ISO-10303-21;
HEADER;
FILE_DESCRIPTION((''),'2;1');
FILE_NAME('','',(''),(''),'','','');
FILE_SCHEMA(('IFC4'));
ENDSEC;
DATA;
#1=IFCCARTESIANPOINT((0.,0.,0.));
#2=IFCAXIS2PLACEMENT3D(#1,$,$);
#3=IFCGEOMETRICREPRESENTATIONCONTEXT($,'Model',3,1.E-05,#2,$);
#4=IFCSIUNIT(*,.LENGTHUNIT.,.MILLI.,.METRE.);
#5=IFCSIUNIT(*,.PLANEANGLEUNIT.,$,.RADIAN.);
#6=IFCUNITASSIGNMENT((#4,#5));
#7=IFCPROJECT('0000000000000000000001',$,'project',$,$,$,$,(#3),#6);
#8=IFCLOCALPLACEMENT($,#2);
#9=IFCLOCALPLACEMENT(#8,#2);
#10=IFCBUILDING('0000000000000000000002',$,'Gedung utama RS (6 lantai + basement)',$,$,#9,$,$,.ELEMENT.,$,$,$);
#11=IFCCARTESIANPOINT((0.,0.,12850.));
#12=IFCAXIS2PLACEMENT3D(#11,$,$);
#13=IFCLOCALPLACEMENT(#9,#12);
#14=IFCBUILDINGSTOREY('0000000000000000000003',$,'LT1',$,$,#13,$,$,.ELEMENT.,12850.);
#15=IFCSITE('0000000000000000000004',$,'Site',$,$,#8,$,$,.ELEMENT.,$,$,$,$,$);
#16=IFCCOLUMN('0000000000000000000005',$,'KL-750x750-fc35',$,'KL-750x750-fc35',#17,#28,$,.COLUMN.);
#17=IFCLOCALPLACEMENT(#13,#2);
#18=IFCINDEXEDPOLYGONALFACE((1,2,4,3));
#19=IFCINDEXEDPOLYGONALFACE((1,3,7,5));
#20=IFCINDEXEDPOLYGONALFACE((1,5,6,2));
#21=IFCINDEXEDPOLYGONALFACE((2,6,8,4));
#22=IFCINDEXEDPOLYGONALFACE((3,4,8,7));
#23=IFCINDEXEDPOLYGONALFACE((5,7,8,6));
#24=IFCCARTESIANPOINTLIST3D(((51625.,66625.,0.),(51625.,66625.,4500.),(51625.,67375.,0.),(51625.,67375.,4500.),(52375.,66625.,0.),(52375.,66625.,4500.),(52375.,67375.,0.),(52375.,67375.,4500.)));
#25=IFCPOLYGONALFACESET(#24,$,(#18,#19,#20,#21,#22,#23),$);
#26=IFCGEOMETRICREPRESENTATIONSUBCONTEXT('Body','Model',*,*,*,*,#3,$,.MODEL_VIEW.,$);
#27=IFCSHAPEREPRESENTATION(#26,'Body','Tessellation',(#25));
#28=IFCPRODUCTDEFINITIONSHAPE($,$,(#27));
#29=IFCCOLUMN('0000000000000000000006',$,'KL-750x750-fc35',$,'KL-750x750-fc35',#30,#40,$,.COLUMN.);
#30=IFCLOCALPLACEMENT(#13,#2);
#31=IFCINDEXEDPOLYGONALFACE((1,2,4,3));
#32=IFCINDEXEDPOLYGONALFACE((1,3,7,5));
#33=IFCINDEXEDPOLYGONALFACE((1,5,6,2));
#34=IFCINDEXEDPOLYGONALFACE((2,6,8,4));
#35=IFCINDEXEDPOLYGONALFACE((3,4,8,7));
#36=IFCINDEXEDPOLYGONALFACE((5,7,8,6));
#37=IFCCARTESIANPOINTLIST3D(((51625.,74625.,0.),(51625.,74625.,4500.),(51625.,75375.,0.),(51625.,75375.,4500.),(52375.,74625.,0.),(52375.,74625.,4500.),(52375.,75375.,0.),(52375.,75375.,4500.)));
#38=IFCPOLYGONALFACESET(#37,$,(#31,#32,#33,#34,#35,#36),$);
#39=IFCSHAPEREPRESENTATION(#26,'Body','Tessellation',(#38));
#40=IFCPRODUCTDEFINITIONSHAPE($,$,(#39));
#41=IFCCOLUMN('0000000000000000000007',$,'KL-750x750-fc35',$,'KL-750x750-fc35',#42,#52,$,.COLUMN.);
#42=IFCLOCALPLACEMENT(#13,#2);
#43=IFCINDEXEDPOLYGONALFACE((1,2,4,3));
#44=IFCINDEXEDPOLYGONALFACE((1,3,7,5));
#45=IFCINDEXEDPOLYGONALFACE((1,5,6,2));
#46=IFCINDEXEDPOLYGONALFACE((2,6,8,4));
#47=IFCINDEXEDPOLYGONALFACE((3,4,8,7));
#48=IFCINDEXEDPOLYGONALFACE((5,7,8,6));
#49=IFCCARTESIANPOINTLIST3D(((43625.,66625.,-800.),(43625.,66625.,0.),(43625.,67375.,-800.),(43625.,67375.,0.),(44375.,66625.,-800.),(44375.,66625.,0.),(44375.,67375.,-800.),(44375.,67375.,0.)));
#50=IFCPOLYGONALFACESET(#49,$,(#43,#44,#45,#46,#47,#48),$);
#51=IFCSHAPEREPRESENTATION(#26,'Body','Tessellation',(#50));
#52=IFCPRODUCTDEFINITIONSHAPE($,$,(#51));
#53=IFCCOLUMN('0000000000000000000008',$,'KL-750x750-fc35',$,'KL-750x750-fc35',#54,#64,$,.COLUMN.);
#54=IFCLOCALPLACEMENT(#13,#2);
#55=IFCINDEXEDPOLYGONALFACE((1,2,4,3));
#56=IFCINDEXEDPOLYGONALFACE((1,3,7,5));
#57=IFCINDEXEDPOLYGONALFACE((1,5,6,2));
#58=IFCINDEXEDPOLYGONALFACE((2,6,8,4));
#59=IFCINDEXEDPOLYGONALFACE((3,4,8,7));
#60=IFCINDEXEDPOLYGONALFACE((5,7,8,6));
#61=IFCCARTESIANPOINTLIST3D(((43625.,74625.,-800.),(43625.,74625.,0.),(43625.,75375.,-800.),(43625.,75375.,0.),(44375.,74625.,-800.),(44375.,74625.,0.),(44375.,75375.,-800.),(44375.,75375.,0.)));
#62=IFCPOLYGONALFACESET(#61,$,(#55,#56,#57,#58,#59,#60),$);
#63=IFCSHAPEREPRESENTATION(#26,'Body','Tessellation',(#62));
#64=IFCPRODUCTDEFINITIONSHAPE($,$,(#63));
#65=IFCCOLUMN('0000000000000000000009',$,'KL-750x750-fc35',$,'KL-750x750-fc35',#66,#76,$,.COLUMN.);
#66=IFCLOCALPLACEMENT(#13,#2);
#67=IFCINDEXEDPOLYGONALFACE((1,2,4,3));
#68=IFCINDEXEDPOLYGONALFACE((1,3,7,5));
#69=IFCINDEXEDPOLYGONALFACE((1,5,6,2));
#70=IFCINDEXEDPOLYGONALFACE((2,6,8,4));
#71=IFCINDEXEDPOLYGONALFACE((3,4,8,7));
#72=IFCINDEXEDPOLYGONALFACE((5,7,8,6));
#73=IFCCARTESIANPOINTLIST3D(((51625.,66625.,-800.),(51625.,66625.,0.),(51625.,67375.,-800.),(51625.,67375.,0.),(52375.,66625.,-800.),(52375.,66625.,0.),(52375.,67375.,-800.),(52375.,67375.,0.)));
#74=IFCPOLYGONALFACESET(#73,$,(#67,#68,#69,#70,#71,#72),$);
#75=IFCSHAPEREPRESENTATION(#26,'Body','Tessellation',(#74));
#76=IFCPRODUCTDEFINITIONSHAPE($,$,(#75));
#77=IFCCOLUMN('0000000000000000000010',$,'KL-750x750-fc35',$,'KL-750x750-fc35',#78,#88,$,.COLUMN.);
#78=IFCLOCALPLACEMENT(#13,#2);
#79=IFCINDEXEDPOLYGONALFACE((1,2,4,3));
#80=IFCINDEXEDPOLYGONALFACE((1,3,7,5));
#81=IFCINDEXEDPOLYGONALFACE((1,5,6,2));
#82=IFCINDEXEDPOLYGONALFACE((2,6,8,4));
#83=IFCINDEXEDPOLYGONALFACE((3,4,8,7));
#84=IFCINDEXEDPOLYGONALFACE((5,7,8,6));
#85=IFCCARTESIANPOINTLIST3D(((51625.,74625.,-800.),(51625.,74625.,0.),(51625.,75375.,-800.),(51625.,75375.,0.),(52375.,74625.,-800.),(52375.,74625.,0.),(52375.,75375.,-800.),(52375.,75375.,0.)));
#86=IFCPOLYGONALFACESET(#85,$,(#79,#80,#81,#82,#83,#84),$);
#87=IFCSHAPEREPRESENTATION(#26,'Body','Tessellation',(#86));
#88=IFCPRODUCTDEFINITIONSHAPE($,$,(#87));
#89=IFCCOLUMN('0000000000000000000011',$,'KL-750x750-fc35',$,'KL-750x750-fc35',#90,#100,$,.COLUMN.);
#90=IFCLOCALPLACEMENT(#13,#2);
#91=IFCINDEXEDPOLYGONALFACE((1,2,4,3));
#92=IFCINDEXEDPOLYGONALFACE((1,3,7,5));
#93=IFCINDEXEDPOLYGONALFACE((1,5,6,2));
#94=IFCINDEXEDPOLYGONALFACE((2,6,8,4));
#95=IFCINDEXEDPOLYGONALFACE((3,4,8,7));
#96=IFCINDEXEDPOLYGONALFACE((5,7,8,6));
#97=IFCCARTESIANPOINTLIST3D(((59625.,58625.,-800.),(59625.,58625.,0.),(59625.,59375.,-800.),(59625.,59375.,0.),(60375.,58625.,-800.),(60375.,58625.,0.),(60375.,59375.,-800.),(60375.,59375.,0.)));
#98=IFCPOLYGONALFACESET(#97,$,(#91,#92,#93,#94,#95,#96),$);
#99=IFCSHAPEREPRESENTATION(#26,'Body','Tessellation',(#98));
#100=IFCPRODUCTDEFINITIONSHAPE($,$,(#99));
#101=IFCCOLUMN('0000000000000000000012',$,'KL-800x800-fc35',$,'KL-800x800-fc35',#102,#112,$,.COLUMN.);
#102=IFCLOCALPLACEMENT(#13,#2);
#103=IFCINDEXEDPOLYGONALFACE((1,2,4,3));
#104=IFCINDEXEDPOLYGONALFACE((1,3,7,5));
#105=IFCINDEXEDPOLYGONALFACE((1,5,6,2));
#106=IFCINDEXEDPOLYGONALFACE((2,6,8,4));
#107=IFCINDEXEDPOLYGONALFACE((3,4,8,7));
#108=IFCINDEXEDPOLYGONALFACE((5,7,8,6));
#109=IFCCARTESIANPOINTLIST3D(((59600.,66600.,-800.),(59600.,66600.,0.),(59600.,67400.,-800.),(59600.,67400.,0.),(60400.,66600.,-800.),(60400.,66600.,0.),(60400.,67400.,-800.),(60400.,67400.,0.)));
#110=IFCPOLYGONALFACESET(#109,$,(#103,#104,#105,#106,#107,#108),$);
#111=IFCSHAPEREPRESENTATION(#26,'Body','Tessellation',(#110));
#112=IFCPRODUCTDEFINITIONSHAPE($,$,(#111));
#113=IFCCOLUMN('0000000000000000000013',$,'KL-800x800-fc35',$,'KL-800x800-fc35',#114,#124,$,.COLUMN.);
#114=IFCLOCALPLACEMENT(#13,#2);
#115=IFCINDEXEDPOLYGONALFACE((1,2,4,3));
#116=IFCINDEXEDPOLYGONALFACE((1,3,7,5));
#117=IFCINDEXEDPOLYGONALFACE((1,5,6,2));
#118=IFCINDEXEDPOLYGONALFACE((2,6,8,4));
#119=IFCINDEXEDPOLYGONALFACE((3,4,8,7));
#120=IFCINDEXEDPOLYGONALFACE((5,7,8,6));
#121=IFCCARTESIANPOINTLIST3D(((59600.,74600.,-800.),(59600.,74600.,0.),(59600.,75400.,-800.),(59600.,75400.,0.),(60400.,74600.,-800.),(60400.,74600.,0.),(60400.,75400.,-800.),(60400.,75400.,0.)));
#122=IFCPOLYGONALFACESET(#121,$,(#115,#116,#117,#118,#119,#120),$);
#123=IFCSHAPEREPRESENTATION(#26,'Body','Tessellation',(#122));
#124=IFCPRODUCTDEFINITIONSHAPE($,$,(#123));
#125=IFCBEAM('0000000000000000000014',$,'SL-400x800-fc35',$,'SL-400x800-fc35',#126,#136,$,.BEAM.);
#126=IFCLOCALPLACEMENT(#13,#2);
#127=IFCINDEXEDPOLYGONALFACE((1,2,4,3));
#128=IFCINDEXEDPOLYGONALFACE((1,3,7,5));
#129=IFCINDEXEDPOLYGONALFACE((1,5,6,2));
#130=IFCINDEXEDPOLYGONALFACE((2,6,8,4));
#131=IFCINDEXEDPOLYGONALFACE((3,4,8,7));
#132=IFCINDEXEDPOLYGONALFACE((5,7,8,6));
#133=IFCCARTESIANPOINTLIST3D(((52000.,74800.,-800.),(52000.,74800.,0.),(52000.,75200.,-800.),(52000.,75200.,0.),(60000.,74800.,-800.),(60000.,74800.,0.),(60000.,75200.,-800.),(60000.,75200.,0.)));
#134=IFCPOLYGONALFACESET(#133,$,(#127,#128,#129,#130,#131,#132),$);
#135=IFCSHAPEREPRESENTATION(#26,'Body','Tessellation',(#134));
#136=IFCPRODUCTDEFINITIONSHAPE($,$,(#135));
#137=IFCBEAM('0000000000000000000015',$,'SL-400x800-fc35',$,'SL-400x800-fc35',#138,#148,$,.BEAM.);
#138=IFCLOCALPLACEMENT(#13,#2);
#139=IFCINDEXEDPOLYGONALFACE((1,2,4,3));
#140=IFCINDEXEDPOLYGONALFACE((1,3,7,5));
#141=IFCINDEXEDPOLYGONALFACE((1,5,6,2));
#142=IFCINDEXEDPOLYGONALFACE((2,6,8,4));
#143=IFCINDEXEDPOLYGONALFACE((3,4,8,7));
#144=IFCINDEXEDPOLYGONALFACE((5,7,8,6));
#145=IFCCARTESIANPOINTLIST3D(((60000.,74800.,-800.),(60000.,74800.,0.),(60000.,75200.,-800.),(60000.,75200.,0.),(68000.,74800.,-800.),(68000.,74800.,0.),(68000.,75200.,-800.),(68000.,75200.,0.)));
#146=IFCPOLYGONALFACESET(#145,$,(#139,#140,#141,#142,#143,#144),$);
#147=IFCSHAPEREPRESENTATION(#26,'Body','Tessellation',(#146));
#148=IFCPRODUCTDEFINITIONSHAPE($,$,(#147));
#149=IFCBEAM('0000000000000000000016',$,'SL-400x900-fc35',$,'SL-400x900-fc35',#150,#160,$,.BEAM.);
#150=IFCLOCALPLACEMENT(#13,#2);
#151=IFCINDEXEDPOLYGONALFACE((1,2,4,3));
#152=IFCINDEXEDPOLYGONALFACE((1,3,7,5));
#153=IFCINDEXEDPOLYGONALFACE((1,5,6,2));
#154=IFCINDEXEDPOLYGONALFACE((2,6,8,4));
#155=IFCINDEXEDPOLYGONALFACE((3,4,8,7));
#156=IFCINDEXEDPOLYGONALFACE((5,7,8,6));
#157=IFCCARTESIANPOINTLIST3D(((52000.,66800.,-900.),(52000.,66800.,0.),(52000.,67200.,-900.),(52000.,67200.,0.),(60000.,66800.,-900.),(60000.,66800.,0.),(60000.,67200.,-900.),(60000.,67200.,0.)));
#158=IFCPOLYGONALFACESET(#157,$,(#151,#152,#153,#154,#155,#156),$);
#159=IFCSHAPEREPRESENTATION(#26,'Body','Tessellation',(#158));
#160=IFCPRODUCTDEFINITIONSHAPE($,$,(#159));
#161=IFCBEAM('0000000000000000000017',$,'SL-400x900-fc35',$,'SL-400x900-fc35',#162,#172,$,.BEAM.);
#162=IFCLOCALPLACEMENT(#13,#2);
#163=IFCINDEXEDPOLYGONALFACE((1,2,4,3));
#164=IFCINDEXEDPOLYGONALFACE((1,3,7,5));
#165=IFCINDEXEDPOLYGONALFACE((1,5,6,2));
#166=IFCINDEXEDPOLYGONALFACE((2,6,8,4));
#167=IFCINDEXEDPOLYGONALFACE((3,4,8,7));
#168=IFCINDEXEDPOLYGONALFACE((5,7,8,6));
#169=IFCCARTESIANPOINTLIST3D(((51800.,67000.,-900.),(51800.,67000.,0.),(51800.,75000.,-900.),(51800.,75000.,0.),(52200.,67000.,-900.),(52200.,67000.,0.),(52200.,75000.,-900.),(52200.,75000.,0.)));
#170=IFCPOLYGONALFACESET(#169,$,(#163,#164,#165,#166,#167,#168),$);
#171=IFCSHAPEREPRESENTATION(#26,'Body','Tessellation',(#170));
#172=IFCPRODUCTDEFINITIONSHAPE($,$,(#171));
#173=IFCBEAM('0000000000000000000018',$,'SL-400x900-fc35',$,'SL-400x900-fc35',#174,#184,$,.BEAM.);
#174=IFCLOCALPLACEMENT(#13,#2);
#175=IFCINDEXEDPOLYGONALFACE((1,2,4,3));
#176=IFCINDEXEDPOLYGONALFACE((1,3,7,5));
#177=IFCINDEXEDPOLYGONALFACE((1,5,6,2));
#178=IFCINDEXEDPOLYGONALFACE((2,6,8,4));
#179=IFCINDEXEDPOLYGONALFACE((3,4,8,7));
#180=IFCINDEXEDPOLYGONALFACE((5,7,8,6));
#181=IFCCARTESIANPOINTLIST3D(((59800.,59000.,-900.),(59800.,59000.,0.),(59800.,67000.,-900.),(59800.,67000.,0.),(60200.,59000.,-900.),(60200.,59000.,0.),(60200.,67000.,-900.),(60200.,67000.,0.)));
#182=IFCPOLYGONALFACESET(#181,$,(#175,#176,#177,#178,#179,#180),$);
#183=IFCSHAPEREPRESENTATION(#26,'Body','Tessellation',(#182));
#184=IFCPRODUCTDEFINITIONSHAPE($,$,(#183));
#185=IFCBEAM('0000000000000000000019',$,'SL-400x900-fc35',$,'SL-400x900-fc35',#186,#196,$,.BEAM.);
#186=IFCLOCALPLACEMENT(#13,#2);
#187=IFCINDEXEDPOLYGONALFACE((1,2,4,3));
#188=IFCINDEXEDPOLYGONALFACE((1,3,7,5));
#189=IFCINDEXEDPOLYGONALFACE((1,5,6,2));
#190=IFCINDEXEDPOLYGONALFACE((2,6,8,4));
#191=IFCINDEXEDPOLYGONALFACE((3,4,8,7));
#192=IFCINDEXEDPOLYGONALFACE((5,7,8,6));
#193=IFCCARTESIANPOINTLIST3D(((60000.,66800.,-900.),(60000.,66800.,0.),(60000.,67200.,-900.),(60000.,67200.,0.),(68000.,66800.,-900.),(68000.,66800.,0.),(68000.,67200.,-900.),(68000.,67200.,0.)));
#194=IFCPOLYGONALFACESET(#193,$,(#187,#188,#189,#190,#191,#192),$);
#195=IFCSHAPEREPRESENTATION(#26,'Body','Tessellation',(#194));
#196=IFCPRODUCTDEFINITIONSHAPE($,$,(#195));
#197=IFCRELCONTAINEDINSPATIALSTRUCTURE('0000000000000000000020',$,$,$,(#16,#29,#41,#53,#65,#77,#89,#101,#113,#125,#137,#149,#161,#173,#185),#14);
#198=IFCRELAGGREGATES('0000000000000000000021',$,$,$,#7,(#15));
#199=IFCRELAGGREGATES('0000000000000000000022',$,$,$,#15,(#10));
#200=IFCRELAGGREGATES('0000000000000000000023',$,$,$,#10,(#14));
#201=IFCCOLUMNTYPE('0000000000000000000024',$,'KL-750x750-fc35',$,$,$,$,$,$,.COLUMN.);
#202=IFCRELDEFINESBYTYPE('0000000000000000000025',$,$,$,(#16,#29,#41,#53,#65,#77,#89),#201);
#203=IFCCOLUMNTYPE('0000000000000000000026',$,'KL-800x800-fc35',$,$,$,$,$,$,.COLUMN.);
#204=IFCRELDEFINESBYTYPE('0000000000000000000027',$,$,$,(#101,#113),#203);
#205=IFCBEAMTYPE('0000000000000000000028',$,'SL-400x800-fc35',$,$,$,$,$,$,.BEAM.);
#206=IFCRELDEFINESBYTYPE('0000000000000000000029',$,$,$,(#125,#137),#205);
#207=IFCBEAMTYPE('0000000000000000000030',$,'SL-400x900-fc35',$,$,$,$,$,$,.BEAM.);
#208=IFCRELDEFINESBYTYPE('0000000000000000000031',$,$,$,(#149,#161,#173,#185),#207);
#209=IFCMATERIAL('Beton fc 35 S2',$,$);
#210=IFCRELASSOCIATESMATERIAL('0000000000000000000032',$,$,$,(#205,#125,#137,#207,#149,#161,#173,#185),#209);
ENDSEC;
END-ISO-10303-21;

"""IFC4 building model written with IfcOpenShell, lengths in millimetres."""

from ifc_helpers import new_model, si_unit, frame, origin, origin_2d, place, context, subcontext, project, spatial, rectangle, extrude, material, material_profile, profile_set, profile_usage, type_object, element, save


model = new_model("IFC4")

# Units and contexts
model_context = context("Model", 3, precision=1e-05, world=origin())
body_context = subcontext(model_context, "Body", "Model", "MODEL_VIEW")
ifc_project = project(units=[si_unit("LENGTHUNIT", "METRE", prefix="MILLI"), si_unit("PLANEANGLEUNIT", "RADIAN")], contexts=[model_context])

# Site, building, storey
site_placement = place(None, origin())
site = spatial("IfcSite", under=ifc_project, at=site_placement, Name="Site", CompositionType="ELEMENT")
building_placement = place(site_placement, origin())
building = spatial("IfcBuilding", under=site, at=building_placement, Name="Gedung utama RS (6 lantai + basement)", CompositionType="ELEMENT")
storey_placement = place(building_placement, frame((0.0, 0.0, 12850.0)))
storey = spatial("IfcBuildingStorey", under=building, at=storey_placement, Name="LT1", CompositionType="ELEMENT", Elevation=12850.0)

# Columns
ifc_material_profile_1 = material_profile(None, rectangle(XDim=750.0, YDim=750.0, at=origin_2d()), Name="KL-750x750-fc35")
ifc_profile_set_1 = profile_set([ifc_material_profile_1], Name="KL-750x750-fc35")
ifc_profile_usage_1 = profile_usage(ifc_profile_set_1, cardinal=5)
column_type_1 = type_object("IfcColumnType", Name="KL-750x750-fc35", PredefinedType="COLUMN", material=ifc_profile_set_1)
for number, where, z_axis, x_axis, name in (
    (1, (52000.0, 67000.0, 0.0), (0.0, 0.0, 1.0), (1.0, 0.0, 0.0), "KL-750x750-fc35"),
    (2, (52000.0, 75000.0, 0.0), (0.0, 0.0, 1.0), (1.0, 0.0, 0.0), "KL-750x750-fc35"),
):
    element("IfcColumn", number, at=place(storey_placement, frame(where, z_axis=z_axis, x_axis=x_axis)), inside=storey, type_object=column_type_1, material=ifc_profile_usage_1, Name=name, ObjectType="KL-750x750-fc35", PredefinedType="COLUMN", context=body_context, shape_type="SweptSolid", body=[
        extrude(rectangle(XDim=750.0, YDim=750.0, at=origin_2d()), origin(), (0.0, 0.0, 1.0), 4500.0),
    ])
for number, where, z_axis, x_axis, name in (
    (3, (44000.0, 67000.0, -800.0), (0.0, 0.0, 1.0), (1.0, 0.0, 0.0), "KL-750x750-fc35"),
    (4, (44000.0, 75000.0, -800.0), (0.0, 0.0, 1.0), (1.0, 0.0, 0.0), "KL-750x750-fc35"),
    (5, (52000.0, 67000.0, -800.0), (0.0, 0.0, 1.0), (1.0, 0.0, 0.0), "KL-750x750-fc35"),
    (6, (52000.0, 75000.0, -800.0), (0.0, 0.0, 1.0), (1.0, 0.0, 0.0), "KL-750x750-fc35"),
    (7, (60000.0, 59000.0, -800.0), (0.0, 0.0, 1.0), (1.0, 0.0, 0.0), "KL-750x750-fc35"),
):
    element("IfcColumn", number, at=place(storey_placement, frame(where, z_axis=z_axis, x_axis=x_axis)), inside=storey, type_object=column_type_1, material=ifc_profile_usage_1, Name=name, ObjectType="KL-750x750-fc35", PredefinedType="COLUMN", context=body_context, shape_type="SweptSolid", body=[
        extrude(rectangle(XDim=750.0, YDim=750.0, at=origin_2d()), origin(), (0.0, 0.0, 1.0), 800.0),
    ])
ifc_material_profile_2 = material_profile(None, rectangle(XDim=800.0, YDim=800.0, at=origin_2d()), Name="KL-800x800-fc35")
ifc_profile_set_2 = profile_set([ifc_material_profile_2], Name="KL-800x800-fc35")
ifc_profile_usage_2 = profile_usage(ifc_profile_set_2, cardinal=5)
column_type_2 = type_object("IfcColumnType", Name="KL-800x800-fc35", PredefinedType="COLUMN", material=ifc_profile_set_2)
for number, where, z_axis, x_axis, name in (
    (8, (60000.0, 67000.0, -800.0), (0.0, 0.0, 1.0), (1.0, 0.0, 0.0), "KL-800x800-fc35"),
    (9, (60000.0, 75000.0, -800.0), (0.0, 0.0, 1.0), (1.0, 0.0, 0.0), "KL-800x800-fc35"),
):
    element("IfcColumn", number, at=place(storey_placement, frame(where, z_axis=z_axis, x_axis=x_axis)), inside=storey, type_object=column_type_2, material=ifc_profile_usage_2, Name=name, ObjectType="KL-800x800-fc35", PredefinedType="COLUMN", context=body_context, shape_type="SweptSolid", body=[
        extrude(rectangle(XDim=800.0, YDim=800.0, at=origin_2d()), origin(), (0.0, 0.0, 1.0), 800.0),
    ])

# Beams
ifc_material = material(Name="Beton fc 35 S2")
ifc_material_profile_3 = material_profile(ifc_material, rectangle(XDim=400.0, YDim=800.0, at=origin_2d()), Name="SL-400x800-fc35")
ifc_profile_set_3 = profile_set([ifc_material_profile_3], Name="SL-400x800-fc35")
ifc_profile_usage_3 = profile_usage(ifc_profile_set_3, cardinal=8)
beam_type_1 = type_object("IfcBeamType", Name="SL-400x800-fc35", PredefinedType="BEAM", material=ifc_profile_set_3)
for number, where, name in (
    (10, (52000.0, 75000.0, -400.0), "SL-400x800-fc35"),
    (11, (60000.0, 75000.0, -400.0), "SL-400x800-fc35"),
):
    element("IfcBeam", number, at=place(storey_placement, frame(where)), inside=storey, type_object=beam_type_1, material=ifc_profile_usage_3, Name=name, ObjectType="SL-400x800-fc35", PredefinedType="BEAM", context=body_context, shape_type="SweptSolid", body=[
        extrude(rectangle(XDim=400.0, YDim=800.0, at=origin_2d()), frame((0.0, 0.0, 0.0), z_axis=(1.0, 0.0, 0.0), x_axis=(0.0, 1.0, 0.0)), (0.0, 0.0, 1.0), 8000.0),
    ])
ifc_material_profile_4 = material_profile(ifc_material, rectangle(XDim=400.0, YDim=900.0, at=origin_2d()), Name="SL-400x900-fc35")
ifc_profile_set_4 = profile_set([ifc_material_profile_4], Name="SL-400x900-fc35")
ifc_profile_usage_4 = profile_usage(ifc_profile_set_4, cardinal=8)
beam_type_2 = type_object("IfcBeamType", Name="SL-400x900-fc35", PredefinedType="BEAM", material=ifc_profile_set_4)
beam_1_placement = place(storey_placement, frame((52000.0, 67000.0, -450.0)))
element("IfcBeam", 12, at=beam_1_placement, inside=storey, type_object=beam_type_2, material=ifc_profile_usage_4, Name="SL-400x900-fc35", ObjectType="SL-400x900-fc35", PredefinedType="BEAM", context=body_context, shape_type="SweptSolid", body=[
    extrude(rectangle(XDim=400.0, YDim=900.0, at=origin_2d()), frame((0.0, 0.0, 0.0), z_axis=(1.0, 0.0, 0.0), x_axis=(0.0, 1.0, 0.0)), (0.0, 0.0, 1.0), 8000.0),
])
for number, where, name in (
    (13, (52000.0, 67000.0, -450.0), "SL-400x900-fc35"),
    (14, (60000.0, 59000.0, -450.0), "SL-400x900-fc35"),
):
    element("IfcBeam", number, at=place(storey_placement, frame(where)), inside=storey, type_object=beam_type_2, material=ifc_profile_usage_4, Name=name, ObjectType="SL-400x900-fc35", PredefinedType="BEAM", context=body_context, shape_type="SweptSolid", body=[
        extrude(rectangle(XDim=400.0, YDim=900.0, at=origin_2d()), frame((0.0, 0.0, 0.0), z_axis=(0.0, 1.0, 0.0), x_axis=(-1.0, 0.0, 0.0)), (0.0, 0.0, 1.0), 8000.0),
    ])
beam_2_placement = place(storey_placement, frame((60000.0, 67000.0, -450.0)))
element("IfcBeam", 15, at=beam_2_placement, inside=storey, type_object=beam_type_2, material=ifc_profile_usage_4, Name="SL-400x900-fc35", ObjectType="SL-400x900-fc35", PredefinedType="BEAM", context=body_context, shape_type="SweptSolid", body=[
    extrude(rectangle(XDim=400.0, YDim=900.0, at=origin_2d()), frame((0.0, 0.0, 0.0), z_axis=(1.0, 0.0, 0.0), x_axis=(0.0, 1.0, 0.0)), (0.0, 0.0, 1.0), 8000.0),
])

save(model, "model.ifc")
